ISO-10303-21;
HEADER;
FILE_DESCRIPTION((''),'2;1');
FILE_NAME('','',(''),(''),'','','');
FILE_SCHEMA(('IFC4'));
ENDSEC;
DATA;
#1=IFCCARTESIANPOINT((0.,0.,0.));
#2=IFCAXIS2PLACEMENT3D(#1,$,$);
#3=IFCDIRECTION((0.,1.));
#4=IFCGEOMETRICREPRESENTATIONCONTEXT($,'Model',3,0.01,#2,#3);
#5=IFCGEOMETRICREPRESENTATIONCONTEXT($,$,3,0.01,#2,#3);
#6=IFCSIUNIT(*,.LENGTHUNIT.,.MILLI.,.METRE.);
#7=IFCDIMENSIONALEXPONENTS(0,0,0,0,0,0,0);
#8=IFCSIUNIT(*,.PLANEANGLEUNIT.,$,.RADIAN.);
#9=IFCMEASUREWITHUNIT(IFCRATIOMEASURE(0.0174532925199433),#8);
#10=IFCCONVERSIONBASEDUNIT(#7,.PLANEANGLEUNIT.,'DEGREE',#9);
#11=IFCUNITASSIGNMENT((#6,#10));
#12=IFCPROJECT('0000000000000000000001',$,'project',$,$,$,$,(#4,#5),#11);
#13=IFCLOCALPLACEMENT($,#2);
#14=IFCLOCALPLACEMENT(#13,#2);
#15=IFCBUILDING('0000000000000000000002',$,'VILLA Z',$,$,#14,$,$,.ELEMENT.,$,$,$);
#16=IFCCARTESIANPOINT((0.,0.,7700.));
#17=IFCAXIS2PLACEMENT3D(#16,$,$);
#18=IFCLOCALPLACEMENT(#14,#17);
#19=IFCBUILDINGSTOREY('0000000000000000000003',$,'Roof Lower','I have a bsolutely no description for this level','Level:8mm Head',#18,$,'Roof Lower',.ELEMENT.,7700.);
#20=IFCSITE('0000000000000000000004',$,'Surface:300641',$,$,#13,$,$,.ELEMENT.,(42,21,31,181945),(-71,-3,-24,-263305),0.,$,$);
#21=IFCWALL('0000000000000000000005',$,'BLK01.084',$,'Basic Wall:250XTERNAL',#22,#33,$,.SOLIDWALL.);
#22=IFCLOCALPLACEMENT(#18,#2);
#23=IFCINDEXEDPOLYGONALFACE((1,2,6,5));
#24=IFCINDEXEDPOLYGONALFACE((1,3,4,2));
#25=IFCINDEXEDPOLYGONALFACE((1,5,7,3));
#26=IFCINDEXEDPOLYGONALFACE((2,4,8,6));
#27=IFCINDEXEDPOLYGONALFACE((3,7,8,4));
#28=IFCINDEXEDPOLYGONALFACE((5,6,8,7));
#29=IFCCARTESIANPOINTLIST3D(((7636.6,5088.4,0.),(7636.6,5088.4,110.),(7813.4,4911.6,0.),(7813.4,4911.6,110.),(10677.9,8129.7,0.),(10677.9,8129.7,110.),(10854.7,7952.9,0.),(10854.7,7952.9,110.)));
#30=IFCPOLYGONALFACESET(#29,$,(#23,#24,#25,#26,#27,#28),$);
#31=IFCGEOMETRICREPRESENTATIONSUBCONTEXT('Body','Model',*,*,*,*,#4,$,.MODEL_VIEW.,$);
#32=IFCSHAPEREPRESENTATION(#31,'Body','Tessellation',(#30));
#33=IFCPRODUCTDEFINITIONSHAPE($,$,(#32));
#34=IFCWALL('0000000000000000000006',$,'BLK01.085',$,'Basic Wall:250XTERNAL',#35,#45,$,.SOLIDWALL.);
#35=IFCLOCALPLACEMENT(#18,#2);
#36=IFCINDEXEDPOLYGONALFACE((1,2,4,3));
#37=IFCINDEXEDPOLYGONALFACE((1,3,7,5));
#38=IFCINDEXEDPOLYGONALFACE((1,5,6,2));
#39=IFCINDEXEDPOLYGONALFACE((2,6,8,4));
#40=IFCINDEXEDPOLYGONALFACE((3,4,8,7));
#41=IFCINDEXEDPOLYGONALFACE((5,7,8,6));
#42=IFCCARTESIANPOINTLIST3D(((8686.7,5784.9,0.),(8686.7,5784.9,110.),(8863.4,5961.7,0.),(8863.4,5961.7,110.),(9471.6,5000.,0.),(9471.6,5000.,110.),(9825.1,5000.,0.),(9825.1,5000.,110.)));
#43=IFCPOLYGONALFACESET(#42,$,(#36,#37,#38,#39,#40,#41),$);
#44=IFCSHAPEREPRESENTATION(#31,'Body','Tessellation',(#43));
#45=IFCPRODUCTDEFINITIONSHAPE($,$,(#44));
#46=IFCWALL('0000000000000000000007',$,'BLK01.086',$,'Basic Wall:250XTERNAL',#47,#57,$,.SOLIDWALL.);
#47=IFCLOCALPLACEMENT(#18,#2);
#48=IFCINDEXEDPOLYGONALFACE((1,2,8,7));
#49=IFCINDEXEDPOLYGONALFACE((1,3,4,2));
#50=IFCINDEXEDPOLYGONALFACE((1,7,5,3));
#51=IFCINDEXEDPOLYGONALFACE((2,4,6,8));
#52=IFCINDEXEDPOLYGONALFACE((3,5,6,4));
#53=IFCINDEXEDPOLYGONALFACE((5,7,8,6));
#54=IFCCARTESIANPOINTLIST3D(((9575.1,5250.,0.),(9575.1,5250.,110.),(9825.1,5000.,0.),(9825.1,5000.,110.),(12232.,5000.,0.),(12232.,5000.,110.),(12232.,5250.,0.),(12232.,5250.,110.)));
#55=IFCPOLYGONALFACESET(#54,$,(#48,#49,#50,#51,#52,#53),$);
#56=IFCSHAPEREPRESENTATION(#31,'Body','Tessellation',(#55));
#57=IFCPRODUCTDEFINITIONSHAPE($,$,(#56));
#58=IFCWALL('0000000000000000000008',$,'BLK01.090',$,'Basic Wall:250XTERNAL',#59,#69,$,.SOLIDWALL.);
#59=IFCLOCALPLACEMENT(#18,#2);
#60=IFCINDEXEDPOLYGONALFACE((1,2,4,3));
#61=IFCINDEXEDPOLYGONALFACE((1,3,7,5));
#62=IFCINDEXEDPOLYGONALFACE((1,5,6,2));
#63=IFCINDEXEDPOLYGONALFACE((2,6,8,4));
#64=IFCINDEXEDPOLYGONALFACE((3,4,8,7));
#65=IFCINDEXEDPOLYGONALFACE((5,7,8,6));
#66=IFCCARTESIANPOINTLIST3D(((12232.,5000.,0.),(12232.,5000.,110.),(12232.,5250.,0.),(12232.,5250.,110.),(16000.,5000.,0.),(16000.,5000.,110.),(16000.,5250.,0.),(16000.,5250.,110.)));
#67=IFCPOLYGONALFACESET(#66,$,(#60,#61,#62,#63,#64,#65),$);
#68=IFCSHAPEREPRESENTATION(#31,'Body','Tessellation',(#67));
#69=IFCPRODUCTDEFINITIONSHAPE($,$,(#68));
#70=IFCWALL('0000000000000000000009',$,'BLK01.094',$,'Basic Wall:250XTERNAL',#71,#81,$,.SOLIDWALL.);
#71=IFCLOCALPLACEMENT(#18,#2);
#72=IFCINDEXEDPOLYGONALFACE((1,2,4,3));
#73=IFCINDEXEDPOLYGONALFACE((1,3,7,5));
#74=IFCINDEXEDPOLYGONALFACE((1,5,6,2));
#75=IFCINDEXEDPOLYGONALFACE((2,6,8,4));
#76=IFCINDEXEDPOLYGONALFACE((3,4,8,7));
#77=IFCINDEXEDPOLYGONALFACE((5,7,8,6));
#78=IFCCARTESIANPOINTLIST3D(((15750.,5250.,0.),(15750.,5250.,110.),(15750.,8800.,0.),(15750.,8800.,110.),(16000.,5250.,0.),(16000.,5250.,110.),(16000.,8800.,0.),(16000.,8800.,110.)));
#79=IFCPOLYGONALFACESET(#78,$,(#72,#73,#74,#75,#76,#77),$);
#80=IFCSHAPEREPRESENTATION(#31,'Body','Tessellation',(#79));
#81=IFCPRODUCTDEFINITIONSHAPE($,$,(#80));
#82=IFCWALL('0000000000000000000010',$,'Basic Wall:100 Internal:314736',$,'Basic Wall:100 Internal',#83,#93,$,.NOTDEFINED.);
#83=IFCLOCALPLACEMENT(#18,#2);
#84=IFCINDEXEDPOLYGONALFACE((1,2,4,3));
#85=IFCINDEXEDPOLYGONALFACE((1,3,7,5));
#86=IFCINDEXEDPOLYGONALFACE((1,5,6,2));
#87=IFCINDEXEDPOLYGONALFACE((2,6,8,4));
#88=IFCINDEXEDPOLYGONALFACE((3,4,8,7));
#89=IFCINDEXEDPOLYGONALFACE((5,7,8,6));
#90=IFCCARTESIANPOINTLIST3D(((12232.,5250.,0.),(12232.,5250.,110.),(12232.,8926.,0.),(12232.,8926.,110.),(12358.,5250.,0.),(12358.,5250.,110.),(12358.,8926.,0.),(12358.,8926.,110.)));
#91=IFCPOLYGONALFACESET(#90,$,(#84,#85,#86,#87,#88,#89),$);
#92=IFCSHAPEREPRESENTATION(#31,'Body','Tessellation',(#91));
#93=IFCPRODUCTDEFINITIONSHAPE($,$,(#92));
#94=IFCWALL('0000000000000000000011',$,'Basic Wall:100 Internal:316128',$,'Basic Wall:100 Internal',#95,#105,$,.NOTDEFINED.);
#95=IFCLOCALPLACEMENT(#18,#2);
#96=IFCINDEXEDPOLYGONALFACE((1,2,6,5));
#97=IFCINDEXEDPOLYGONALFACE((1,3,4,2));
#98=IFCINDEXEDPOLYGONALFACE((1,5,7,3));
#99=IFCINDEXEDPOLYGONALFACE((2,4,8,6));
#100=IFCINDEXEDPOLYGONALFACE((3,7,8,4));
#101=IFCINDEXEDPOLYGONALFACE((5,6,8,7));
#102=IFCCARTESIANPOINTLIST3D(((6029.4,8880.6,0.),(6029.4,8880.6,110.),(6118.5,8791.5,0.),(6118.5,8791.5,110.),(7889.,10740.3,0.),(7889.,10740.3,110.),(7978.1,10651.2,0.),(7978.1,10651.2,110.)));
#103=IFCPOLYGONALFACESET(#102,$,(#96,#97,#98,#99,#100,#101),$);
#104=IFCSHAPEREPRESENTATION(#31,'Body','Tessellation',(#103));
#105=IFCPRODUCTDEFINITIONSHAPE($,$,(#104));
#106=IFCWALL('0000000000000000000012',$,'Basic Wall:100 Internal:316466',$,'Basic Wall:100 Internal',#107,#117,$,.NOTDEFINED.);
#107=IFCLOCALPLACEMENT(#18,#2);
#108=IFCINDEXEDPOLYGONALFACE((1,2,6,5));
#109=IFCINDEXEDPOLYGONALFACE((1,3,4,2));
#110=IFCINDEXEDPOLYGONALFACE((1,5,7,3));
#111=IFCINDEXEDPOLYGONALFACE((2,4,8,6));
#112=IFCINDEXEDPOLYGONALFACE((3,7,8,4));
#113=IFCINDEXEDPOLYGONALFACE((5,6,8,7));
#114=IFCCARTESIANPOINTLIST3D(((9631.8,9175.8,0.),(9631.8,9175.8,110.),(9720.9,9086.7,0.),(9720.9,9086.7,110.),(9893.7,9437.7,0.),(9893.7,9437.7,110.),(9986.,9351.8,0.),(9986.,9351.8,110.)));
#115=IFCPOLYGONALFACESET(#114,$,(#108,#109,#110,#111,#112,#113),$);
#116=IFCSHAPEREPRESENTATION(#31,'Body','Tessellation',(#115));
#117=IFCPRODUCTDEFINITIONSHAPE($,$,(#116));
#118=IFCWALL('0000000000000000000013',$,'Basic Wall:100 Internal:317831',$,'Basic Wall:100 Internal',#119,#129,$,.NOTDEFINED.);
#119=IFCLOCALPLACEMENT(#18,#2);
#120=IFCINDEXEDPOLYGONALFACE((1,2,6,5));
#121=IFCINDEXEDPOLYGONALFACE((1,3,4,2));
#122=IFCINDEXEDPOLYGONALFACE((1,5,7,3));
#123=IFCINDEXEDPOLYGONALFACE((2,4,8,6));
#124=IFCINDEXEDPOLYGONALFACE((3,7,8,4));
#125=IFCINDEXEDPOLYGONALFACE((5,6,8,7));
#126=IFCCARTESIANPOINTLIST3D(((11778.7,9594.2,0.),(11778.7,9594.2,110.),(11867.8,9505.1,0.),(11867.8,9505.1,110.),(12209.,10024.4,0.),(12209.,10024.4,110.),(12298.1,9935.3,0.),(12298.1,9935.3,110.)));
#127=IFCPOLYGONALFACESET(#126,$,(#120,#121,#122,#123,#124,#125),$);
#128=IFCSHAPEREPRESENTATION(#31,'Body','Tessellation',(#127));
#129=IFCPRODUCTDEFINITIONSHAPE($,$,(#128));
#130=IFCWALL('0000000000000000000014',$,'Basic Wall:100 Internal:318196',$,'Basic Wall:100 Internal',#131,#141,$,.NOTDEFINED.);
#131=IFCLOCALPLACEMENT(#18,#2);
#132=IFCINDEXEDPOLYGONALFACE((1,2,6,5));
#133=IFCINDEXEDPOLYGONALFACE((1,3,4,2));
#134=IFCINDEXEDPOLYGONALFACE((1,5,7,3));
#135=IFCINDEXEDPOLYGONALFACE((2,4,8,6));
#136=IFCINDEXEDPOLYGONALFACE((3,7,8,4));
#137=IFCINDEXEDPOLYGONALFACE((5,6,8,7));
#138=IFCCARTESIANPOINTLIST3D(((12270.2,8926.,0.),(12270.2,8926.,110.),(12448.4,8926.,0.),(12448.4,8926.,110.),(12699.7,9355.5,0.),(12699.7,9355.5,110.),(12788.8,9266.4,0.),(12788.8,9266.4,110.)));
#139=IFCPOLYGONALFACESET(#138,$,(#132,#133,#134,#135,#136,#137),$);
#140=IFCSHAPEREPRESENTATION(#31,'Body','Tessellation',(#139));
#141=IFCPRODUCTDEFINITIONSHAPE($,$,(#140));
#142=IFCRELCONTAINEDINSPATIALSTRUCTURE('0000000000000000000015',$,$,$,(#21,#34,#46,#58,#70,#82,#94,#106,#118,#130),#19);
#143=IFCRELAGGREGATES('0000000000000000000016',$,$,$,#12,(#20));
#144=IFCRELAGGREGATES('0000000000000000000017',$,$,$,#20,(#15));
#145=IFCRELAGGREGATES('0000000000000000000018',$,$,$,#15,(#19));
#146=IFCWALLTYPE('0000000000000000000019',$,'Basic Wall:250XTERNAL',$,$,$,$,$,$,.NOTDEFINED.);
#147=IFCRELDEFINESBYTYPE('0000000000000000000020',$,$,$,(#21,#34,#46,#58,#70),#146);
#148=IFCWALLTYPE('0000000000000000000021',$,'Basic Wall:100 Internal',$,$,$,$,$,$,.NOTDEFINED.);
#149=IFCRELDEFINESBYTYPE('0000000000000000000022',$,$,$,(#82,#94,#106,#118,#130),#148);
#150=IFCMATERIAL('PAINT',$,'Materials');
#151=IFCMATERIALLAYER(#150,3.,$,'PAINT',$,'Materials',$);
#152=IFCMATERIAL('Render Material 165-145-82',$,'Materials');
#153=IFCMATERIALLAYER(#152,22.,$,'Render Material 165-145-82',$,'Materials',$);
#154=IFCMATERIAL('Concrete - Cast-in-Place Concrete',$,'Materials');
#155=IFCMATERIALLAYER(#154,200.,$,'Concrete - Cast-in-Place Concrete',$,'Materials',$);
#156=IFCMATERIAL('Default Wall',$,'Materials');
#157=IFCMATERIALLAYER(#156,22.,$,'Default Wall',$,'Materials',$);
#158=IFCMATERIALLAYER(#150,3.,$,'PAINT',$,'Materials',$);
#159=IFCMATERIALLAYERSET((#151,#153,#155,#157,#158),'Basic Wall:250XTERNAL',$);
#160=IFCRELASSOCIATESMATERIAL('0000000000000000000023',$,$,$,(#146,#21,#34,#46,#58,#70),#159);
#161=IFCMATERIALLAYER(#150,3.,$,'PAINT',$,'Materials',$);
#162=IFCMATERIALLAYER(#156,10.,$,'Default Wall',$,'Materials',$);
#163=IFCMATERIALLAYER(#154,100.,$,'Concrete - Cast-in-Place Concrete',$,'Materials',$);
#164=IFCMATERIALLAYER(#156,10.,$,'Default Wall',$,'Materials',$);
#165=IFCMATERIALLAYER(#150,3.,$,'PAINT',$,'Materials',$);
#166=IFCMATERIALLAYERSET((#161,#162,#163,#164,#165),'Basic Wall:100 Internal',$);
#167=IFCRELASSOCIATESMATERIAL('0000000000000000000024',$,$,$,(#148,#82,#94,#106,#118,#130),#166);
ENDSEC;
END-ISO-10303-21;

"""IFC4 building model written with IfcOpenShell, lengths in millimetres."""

from ifc_helpers import new_model, entity, si_unit, converted_unit, direction, frame, frame_2d, origin, place, context, subcontext, project, spatial, polyline, rectangle, outline, extrude, clip, halfspace, bounded_halfspace, material, layer, layer_set, layer_usage, type_object, element, save


model = new_model("IFC4")

# Units and contexts
model_context = context("Model", 3, precision=0.01, world=origin(), true_north=direction((0.0, 1.0)))
context_of_model = context(None, 3, precision=0.01, world=origin(), true_north=direction((0.0, 1.0)))
body_context = subcontext(model_context, "Body", "Model", "MODEL_VIEW")
ifc_project = project(units=[si_unit("LENGTHUNIT", "METRE", prefix="MILLI"), converted_unit("PLANEANGLEUNIT", "DEGREE", entity("IfcRatioMeasure", 0.0174532925199433), si_unit("PLANEANGLEUNIT", "RADIAN"), dimensions=[0, 0, 0, 0, 0, 0, 0])], contexts=[model_context, context_of_model])

# Site, building, storey
site_placement = place(None, origin())
site = spatial("IfcSite", under=ifc_project, at=site_placement, Name="Surface:300641", CompositionType="ELEMENT", RefLatitude=(42, 21, 31, 181945), RefLongitude=(-71, -3, -24, -263305), RefElevation=0.0)
building_placement = place(site_placement, origin())
building = spatial("IfcBuilding", under=site, at=building_placement, Name="VILLA Z", CompositionType="ELEMENT")
storey_placement = place(building_placement, frame((0.0, 0.0, 7700.0)))
storey = spatial("IfcBuildingStorey", under=building, at=storey_placement, Name="Roof Lower", Description="I have a bsolutely no description for this level", ObjectType="Level:8mm Head", LongName="Roof Lower", CompositionType="ELEMENT", Elevation=7700.0)

# Shared definitions
ifc_material_1 = material(Name="Concrete - Cast-in-Place Concrete", Category="Materials")

# Walls
ifc_material_2 = material(Name="PAINT", Category="Materials")
ifc_layer_1 = layer(ifc_material_2, 3.0, Name="PAINT", Category="Materials")
ifc_material_3 = material(Name="Render Material 165-145-82", Category="Materials")
ifc_layer_2 = layer(ifc_material_3, 22.0, Name="Render Material 165-145-82", Category="Materials")
ifc_layer_3 = layer(ifc_material_1, 200.0, Name="Concrete - Cast-in-Place Concrete", Category="Materials")
ifc_material_4 = material(Name="Default Wall", Category="Materials")
ifc_layer_4 = layer(ifc_material_4, 22.0, Name="Default Wall", Category="Materials")
ifc_layer_5 = layer(ifc_material_2, 3.0, Name="PAINT", Category="Materials")
ifc_layer_set_1 = layer_set([ifc_layer_1, ifc_layer_2, ifc_layer_3, ifc_layer_4, ifc_layer_5], Name="Basic Wall:250XTERNAL")
ifc_layer_usage_1 = layer_usage(ifc_layer_set_1, "AXIS2", "NEGATIVE", 125.0)
wall_type_1 = type_object("IfcWallType", Name="Basic Wall:250XTERNAL", PredefinedType="NOTDEFINED", material=ifc_layer_set_1)
wall_1_placement = place(storey_placement, frame((7725.0, 5000.0, 0.0), z_axis=(0.0, 0.0, 1.0), x_axis=(0.707107, 0.707107, 0.0)))
element("IfcWall", 1, at=wall_1_placement, inside=storey, type_object=wall_type_1, material=ifc_layer_usage_1, Name="BLK01.084", ObjectType="Basic Wall:250XTERNAL", PredefinedType="SOLIDWALL", context=body_context, shape_type="Clipping", body=[
    clip(clip(extrude(rectangle(XDim=4301.0, YDim=250.0, at=frame_2d((2150.5, 0.0), x_axis=(-1.0, 0.0))), origin(), (0.0, 0.0, 1.0), 110.0), bounded_halfspace(frame((0.0, -125.0, 110.0), z_axis=(0.0, 0.0, -1.0), x_axis=(0.707107, -0.707107, 0.0)), True, frame((0.0, -125.0, 110.0)), polyline([(0.0, 0.0), (1235.0, 0.0), (1485.0, 0.0), (3527.0, 0.0), (3653.0, 0.0), (4301.0, 0.0), (4301.0, 250.0), (4175.0, 250.0), (0.0, 250.0), (0.0, 0.0)]))), halfspace(frame((0.0, 0.0, -3500.0)), True)),
])
ifc_layer_usage_2 = layer_usage(ifc_layer_set_1, "AXIS2", "NEGATIVE", 125.0)
wall_2_placement = place(storey_placement, frame((8775.1, 5873.3, 0.0), z_axis=(0.0, 0.0, 1.0), x_axis=(0.707107, -0.707107, 0.0)))
element("IfcWall", 2, at=wall_2_placement, inside=storey, type_object=wall_type_1, material=ifc_layer_usage_2, Name="BLK01.085", ObjectType="Basic Wall:250XTERNAL", PredefinedType="SOLIDWALL", context=body_context, shape_type="Clipping", body=[
    clip(clip(extrude(outline(polyline([(1110.0, -125.0), (1360.0, 125.0), (1006.4, 125.0), (0.0, 125.0), (0.0, -125.0), (1110.0, -125.0)])), origin(), (0.0, 0.0, 1.0), 110.0), bounded_halfspace(frame((0.0, -125.0, 110.0), z_axis=(0.0, 0.0, -1.0), x_axis=(0.707107, 0.707107, 0.0)), True, frame((0.0, -125.0, 110.0)), polyline([(0.0, 0.0), (1110.0, 0.0), (1360.0, 250.0), (1006.4, 250.0), (0.0, 250.0), (0.0, 0.0)]))), halfspace(frame((0.0, 0.0, -3500.0)), True)),
])
ifc_layer_usage_3 = layer_usage(ifc_layer_set_1, "AXIS2", "NEGATIVE", 125.0)
wall_3_placement = place(storey_placement, frame((9575.1, 5125.0, 0.0)))
element("IfcWall", 3, at=wall_3_placement, inside=storey, type_object=wall_type_1, material=ifc_layer_usage_3, Name="BLK01.086", ObjectType="Basic Wall:250XTERNAL", PredefinedType="SOLIDWALL", context=body_context, shape_type="Clipping", body=[
    clip(clip(extrude(outline(polyline([(2656.9, -125.0), (2656.9, 125.0), (0.0, 125.0), (250.0, -125.0), (2656.9, -125.0)])), origin(), (0.0, 0.0, 1.0), 110.0), bounded_halfspace(frame((2656.9, 125.0, 110.0), z_axis=(0.0, 0.0, -1.0), x_axis=(1.0, 0.0, 0.0)), True, frame((2656.9, 125.0, 110.0)), polyline([(0.0, 0.0), (-2656.9, 0.0), (-2406.9, -250.0), (0.0, -250.0), (0.0, 0.0)]))), halfspace(frame((0.0, 0.0, -3500.0)), True)),
])
ifc_layer_usage_4 = layer_usage(ifc_layer_set_1, "AXIS2", "NEGATIVE", 125.0)
wall_4_placement = place(storey_placement, frame((12232.0, 5125.0, 0.0)))
element("IfcWall", 4, at=wall_4_placement, inside=storey, type_object=wall_type_1, material=ifc_layer_usage_4, Name="BLK01.090", ObjectType="Basic Wall:250XTERNAL", PredefinedType="SOLIDWALL", context=body_context, shape_type="Clipping", body=[
    clip(clip(extrude(rectangle(XDim=3768.0, YDim=250.0, at=frame_2d((1884.0, 0.0), x_axis=(-1.0, 0.0))), origin(), (0.0, 0.0, 1.0), 110.0), bounded_halfspace(frame((3768.0, 125.0, 110.0), z_axis=(0.0, 0.0, -1.0), x_axis=(1.0, 0.0, 0.0)), True, frame((3768.0, 125.0, 110.0)), polyline([(0.0, 0.0), (-250.0, 0.0), (-3642.0, 0.0), (-3768.0, 0.0), (-3768.0, -250.0), (0.0, -250.0), (0.0, 0.0)]))), halfspace(frame((0.0, 0.0, -3500.0)), True)),
])
ifc_layer_usage_5 = layer_usage(ifc_layer_set_1, "AXIS2", "POSITIVE", -125.0)
wall_5_placement = place(storey_placement, frame((15875.0, 5250.0, 0.0), z_axis=(0.0, 0.0, 1.0), x_axis=(0.0, 1.0, 0.0)))
element("IfcWall", 5, at=wall_5_placement, inside=storey, type_object=wall_type_1, material=ifc_layer_usage_5, Name="BLK01.094", ObjectType="Basic Wall:250XTERNAL", PredefinedType="SOLIDWALL", context=body_context, shape_type="Clipping", body=[
    clip(clip(extrude(rectangle(XDim=3550.0, YDim=250.0, at=frame_2d((1775.0, 0.0), x_axis=(-1.0, 0.0))), origin(), (0.0, 0.0, 1.0), 110.0), bounded_halfspace(frame((0.0, -125.0, 110.0), z_axis=(0.0, 0.0, -1.0), x_axis=(0.0, -1.0, 0.0)), True, frame((0.0, -125.0, 110.0)), polyline([(0.0, 0.0), (3550.0, 0.0), (3550.0, 190.0), (3550.0, 250.0), (0.0, 250.0), (0.0, 0.0)]))), halfspace(frame((0.0, 0.0, -3500.0)), True)),
])
ifc_layer_6 = layer(ifc_material_2, 3.0, Name="PAINT", Category="Materials")
ifc_layer_7 = layer(ifc_material_4, 10.0, Name="Default Wall", Category="Materials")
ifc_layer_8 = layer(ifc_material_1, 100.0, Name="Concrete - Cast-in-Place Concrete", Category="Materials")
ifc_layer_9 = layer(ifc_material_4, 10.0, Name="Default Wall", Category="Materials")
ifc_layer_10 = layer(ifc_material_2, 3.0, Name="PAINT", Category="Materials")
ifc_layer_set_2 = layer_set([ifc_layer_6, ifc_layer_7, ifc_layer_8, ifc_layer_9, ifc_layer_10], Name="Basic Wall:100 Internal")
ifc_layer_usage_6 = layer_usage(ifc_layer_set_2, "AXIS2", "NEGATIVE", 63.0)
wall_type_2 = type_object("IfcWallType", Name="Basic Wall:100 Internal", PredefinedType="NOTDEFINED", material=ifc_layer_set_2)
wall_6_placement = place(storey_placement, frame((12295.0, 5250.0, 0.0), z_axis=(0.0, 0.0, 1.0), x_axis=(0.0, 1.0, 0.0)))
element("IfcWall", 6, at=wall_6_placement, inside=storey, type_object=wall_type_2, material=ifc_layer_usage_6, Name="Basic Wall:100 Internal:314736", ObjectType="Basic Wall:100 Internal", PredefinedType="NOTDEFINED", context=body_context, shape_type="Clipping", body=[
    clip(clip(extrude(rectangle(XDim=3676.0, YDim=126.0, at=frame_2d((1838.0, 0.0), x_axis=(-1.0, 0.0))), origin(), (0.0, 0.0, 1.0), 110.0), bounded_halfspace(frame((0.0, -63.0, 110.0), z_axis=(0.0, 0.0, -1.0), x_axis=(0.0, -1.0, 0.0)), True, frame((0.0, -63.0, 110.0)), polyline([(0.0, 0.0), (3550.0, 0.0), (3676.0, 0.0), (3676.0, 87.8), (3676.0, 126.0), (1485.3, 126.0), (1359.3, 126.0), (0.0, 126.0), (0.0, 0.0)]))), halfspace(frame((0.0, 0.0, -3500.0)), True)),
])
ifc_layer_usage_7 = layer_usage(ifc_layer_set_2, "AXIS2", "NEGATIVE", 63.0)
wall_7_placement = place(storey_placement, frame((6073.9, 8836.1, 0.0), z_axis=(0.0, 0.0, 1.0), x_axis=(0.707107, 0.707107, 0.0)))
element("IfcWall", 7, at=wall_7_placement, inside=storey, type_object=wall_type_2, material=ifc_layer_usage_7, Name="Basic Wall:100 Internal:316128", ObjectType="Basic Wall:100 Internal", PredefinedType="NOTDEFINED", context=body_context, shape_type="Clipping", body=[
    clip(clip(extrude(rectangle(XDim=2630.0, YDim=126.0, at=frame_2d((1315.0, 0.0), x_axis=(-1.0, 0.0))), origin(), (0.0, 0.0, 1.0), 110.0), bounded_halfspace(frame((0.0, -63.0, 110.0), z_axis=(0.0, 0.0, -1.0), x_axis=(0.707107, -0.707107, 0.0)), True, frame((0.0, -63.0, 110.0)), polyline([(0.0, 0.0), (2630.0, 0.0), (2630.0, 126.0), (0.0, 126.0), (0.0, 0.0)]))), halfspace(frame((0.0, 0.0, -3500.0)), True)),
])
ifc_layer_usage_8 = layer_usage(ifc_layer_set_2, "AXIS2", "NEGATIVE", 63.0)
wall_8_placement = place(storey_placement, frame((9941.4, 9396.3, 0.0), z_axis=(0.0, 0.0, 1.0), x_axis=(-0.707107, -0.707107, 0.0)))
element("IfcWall", 8, at=wall_8_placement, inside=storey, type_object=wall_type_2, material=ifc_layer_usage_8, Name="Basic Wall:100 Internal:316466", ObjectType="Basic Wall:100 Internal", PredefinedType="NOTDEFINED", context=body_context, shape_type="Clipping", body=[
    clip(clip(extrude(outline(polyline([(374.9, -63.0), (374.9, 63.0), (0.0, 63.0), (4.4, -63.0), (374.9, -63.0)])), origin(), (0.0, 0.0, 1.0), 110.0), bounded_halfspace(frame((4.4, -63.0, 110.0), z_axis=(0.0, 0.0, -1.0), x_axis=(-0.707107, 0.707107, 0.0)), True, frame((4.4, -63.0, 110.0)), polyline([(0.0, 0.0), (370.5, 0.0), (370.5, 126.0), (-4.4, 126.0), (0.0, 0.0)]))), halfspace(frame((0.0, 0.0, -3500.0)), True)),
])
ifc_layer_usage_9 = layer_usage(ifc_layer_set_2, "AXIS2", "NEGATIVE", 63.0)
wall_9_placement = place(storey_placement, frame((11823.3, 9549.6, 0.0), z_axis=(0.0, 0.0, 1.0), x_axis=(0.707107, 0.707107, 0.0)))
element("IfcWall", 9, at=wall_9_placement, inside=storey, type_object=wall_type_2, material=ifc_layer_usage_9, Name="Basic Wall:100 Internal:317831", ObjectType="Basic Wall:100 Internal", PredefinedType="NOTDEFINED", context=body_context, shape_type="Clipping", body=[
    clip(clip(extrude(rectangle(XDim=608.4, YDim=126.0, at=frame_2d((304.2, 0.0), x_axis=(-1.0, 0.0))), origin(), (0.0, 0.0, 1.0), 110.0), bounded_halfspace(frame((0.0, -63.0, 110.0), z_axis=(0.0, 0.0, -1.0), x_axis=(0.707107, -0.707107, 0.0)), True, frame((0.0, -63.0, 110.0)), polyline([(0.0, 0.0), (482.4, 0.0), (608.4, 0.0), (608.4, 126.0), (0.0, 126.0), (0.0, 0.0)]))), halfspace(frame((0.0, 0.0, -3500.0)), True)),
])
ifc_layer_usage_10 = layer_usage(ifc_layer_set_2, "AXIS2", "NEGATIVE", 63.0)
wall_10_placement = place(storey_placement, frame((12744.2, 9310.9, 0.0), z_axis=(0.0, 0.0, 1.0), x_axis=(-0.707107, -0.707107, 0.0)))
element("IfcWall", 10, at=wall_10_placement, inside=storey, type_object=wall_type_2, material=ifc_layer_usage_10, Name="Basic Wall:100 Internal:318196", ObjectType="Basic Wall:100 Internal", PredefinedType="NOTDEFINED", context=body_context, shape_type="Clipping", body=[
    clip(clip(extrude(outline(polyline([(607.4, -63.0), (545.3, -0.9), (481.4, 63.0), (0.0, 63.0), (0.0, -63.0), (607.4, -63.0)])), origin(), (0.0, 0.0, 1.0), 110.0), bounded_halfspace(frame((0.0, -63.0, 110.0), z_axis=(0.0, 0.0, -1.0), x_axis=(-0.707107, 0.707107, 0.0)), True, frame((0.0, -63.0, 110.0)), polyline([(0.0, 0.0), (607.4, 0.0), (545.3, 62.1), (481.4, 126.0), (0.0, 126.0), (0.0, 0.0)]))), halfspace(frame((0.0, 0.0, -3500.0)), True)),
])

save(model, "model.ifc")
